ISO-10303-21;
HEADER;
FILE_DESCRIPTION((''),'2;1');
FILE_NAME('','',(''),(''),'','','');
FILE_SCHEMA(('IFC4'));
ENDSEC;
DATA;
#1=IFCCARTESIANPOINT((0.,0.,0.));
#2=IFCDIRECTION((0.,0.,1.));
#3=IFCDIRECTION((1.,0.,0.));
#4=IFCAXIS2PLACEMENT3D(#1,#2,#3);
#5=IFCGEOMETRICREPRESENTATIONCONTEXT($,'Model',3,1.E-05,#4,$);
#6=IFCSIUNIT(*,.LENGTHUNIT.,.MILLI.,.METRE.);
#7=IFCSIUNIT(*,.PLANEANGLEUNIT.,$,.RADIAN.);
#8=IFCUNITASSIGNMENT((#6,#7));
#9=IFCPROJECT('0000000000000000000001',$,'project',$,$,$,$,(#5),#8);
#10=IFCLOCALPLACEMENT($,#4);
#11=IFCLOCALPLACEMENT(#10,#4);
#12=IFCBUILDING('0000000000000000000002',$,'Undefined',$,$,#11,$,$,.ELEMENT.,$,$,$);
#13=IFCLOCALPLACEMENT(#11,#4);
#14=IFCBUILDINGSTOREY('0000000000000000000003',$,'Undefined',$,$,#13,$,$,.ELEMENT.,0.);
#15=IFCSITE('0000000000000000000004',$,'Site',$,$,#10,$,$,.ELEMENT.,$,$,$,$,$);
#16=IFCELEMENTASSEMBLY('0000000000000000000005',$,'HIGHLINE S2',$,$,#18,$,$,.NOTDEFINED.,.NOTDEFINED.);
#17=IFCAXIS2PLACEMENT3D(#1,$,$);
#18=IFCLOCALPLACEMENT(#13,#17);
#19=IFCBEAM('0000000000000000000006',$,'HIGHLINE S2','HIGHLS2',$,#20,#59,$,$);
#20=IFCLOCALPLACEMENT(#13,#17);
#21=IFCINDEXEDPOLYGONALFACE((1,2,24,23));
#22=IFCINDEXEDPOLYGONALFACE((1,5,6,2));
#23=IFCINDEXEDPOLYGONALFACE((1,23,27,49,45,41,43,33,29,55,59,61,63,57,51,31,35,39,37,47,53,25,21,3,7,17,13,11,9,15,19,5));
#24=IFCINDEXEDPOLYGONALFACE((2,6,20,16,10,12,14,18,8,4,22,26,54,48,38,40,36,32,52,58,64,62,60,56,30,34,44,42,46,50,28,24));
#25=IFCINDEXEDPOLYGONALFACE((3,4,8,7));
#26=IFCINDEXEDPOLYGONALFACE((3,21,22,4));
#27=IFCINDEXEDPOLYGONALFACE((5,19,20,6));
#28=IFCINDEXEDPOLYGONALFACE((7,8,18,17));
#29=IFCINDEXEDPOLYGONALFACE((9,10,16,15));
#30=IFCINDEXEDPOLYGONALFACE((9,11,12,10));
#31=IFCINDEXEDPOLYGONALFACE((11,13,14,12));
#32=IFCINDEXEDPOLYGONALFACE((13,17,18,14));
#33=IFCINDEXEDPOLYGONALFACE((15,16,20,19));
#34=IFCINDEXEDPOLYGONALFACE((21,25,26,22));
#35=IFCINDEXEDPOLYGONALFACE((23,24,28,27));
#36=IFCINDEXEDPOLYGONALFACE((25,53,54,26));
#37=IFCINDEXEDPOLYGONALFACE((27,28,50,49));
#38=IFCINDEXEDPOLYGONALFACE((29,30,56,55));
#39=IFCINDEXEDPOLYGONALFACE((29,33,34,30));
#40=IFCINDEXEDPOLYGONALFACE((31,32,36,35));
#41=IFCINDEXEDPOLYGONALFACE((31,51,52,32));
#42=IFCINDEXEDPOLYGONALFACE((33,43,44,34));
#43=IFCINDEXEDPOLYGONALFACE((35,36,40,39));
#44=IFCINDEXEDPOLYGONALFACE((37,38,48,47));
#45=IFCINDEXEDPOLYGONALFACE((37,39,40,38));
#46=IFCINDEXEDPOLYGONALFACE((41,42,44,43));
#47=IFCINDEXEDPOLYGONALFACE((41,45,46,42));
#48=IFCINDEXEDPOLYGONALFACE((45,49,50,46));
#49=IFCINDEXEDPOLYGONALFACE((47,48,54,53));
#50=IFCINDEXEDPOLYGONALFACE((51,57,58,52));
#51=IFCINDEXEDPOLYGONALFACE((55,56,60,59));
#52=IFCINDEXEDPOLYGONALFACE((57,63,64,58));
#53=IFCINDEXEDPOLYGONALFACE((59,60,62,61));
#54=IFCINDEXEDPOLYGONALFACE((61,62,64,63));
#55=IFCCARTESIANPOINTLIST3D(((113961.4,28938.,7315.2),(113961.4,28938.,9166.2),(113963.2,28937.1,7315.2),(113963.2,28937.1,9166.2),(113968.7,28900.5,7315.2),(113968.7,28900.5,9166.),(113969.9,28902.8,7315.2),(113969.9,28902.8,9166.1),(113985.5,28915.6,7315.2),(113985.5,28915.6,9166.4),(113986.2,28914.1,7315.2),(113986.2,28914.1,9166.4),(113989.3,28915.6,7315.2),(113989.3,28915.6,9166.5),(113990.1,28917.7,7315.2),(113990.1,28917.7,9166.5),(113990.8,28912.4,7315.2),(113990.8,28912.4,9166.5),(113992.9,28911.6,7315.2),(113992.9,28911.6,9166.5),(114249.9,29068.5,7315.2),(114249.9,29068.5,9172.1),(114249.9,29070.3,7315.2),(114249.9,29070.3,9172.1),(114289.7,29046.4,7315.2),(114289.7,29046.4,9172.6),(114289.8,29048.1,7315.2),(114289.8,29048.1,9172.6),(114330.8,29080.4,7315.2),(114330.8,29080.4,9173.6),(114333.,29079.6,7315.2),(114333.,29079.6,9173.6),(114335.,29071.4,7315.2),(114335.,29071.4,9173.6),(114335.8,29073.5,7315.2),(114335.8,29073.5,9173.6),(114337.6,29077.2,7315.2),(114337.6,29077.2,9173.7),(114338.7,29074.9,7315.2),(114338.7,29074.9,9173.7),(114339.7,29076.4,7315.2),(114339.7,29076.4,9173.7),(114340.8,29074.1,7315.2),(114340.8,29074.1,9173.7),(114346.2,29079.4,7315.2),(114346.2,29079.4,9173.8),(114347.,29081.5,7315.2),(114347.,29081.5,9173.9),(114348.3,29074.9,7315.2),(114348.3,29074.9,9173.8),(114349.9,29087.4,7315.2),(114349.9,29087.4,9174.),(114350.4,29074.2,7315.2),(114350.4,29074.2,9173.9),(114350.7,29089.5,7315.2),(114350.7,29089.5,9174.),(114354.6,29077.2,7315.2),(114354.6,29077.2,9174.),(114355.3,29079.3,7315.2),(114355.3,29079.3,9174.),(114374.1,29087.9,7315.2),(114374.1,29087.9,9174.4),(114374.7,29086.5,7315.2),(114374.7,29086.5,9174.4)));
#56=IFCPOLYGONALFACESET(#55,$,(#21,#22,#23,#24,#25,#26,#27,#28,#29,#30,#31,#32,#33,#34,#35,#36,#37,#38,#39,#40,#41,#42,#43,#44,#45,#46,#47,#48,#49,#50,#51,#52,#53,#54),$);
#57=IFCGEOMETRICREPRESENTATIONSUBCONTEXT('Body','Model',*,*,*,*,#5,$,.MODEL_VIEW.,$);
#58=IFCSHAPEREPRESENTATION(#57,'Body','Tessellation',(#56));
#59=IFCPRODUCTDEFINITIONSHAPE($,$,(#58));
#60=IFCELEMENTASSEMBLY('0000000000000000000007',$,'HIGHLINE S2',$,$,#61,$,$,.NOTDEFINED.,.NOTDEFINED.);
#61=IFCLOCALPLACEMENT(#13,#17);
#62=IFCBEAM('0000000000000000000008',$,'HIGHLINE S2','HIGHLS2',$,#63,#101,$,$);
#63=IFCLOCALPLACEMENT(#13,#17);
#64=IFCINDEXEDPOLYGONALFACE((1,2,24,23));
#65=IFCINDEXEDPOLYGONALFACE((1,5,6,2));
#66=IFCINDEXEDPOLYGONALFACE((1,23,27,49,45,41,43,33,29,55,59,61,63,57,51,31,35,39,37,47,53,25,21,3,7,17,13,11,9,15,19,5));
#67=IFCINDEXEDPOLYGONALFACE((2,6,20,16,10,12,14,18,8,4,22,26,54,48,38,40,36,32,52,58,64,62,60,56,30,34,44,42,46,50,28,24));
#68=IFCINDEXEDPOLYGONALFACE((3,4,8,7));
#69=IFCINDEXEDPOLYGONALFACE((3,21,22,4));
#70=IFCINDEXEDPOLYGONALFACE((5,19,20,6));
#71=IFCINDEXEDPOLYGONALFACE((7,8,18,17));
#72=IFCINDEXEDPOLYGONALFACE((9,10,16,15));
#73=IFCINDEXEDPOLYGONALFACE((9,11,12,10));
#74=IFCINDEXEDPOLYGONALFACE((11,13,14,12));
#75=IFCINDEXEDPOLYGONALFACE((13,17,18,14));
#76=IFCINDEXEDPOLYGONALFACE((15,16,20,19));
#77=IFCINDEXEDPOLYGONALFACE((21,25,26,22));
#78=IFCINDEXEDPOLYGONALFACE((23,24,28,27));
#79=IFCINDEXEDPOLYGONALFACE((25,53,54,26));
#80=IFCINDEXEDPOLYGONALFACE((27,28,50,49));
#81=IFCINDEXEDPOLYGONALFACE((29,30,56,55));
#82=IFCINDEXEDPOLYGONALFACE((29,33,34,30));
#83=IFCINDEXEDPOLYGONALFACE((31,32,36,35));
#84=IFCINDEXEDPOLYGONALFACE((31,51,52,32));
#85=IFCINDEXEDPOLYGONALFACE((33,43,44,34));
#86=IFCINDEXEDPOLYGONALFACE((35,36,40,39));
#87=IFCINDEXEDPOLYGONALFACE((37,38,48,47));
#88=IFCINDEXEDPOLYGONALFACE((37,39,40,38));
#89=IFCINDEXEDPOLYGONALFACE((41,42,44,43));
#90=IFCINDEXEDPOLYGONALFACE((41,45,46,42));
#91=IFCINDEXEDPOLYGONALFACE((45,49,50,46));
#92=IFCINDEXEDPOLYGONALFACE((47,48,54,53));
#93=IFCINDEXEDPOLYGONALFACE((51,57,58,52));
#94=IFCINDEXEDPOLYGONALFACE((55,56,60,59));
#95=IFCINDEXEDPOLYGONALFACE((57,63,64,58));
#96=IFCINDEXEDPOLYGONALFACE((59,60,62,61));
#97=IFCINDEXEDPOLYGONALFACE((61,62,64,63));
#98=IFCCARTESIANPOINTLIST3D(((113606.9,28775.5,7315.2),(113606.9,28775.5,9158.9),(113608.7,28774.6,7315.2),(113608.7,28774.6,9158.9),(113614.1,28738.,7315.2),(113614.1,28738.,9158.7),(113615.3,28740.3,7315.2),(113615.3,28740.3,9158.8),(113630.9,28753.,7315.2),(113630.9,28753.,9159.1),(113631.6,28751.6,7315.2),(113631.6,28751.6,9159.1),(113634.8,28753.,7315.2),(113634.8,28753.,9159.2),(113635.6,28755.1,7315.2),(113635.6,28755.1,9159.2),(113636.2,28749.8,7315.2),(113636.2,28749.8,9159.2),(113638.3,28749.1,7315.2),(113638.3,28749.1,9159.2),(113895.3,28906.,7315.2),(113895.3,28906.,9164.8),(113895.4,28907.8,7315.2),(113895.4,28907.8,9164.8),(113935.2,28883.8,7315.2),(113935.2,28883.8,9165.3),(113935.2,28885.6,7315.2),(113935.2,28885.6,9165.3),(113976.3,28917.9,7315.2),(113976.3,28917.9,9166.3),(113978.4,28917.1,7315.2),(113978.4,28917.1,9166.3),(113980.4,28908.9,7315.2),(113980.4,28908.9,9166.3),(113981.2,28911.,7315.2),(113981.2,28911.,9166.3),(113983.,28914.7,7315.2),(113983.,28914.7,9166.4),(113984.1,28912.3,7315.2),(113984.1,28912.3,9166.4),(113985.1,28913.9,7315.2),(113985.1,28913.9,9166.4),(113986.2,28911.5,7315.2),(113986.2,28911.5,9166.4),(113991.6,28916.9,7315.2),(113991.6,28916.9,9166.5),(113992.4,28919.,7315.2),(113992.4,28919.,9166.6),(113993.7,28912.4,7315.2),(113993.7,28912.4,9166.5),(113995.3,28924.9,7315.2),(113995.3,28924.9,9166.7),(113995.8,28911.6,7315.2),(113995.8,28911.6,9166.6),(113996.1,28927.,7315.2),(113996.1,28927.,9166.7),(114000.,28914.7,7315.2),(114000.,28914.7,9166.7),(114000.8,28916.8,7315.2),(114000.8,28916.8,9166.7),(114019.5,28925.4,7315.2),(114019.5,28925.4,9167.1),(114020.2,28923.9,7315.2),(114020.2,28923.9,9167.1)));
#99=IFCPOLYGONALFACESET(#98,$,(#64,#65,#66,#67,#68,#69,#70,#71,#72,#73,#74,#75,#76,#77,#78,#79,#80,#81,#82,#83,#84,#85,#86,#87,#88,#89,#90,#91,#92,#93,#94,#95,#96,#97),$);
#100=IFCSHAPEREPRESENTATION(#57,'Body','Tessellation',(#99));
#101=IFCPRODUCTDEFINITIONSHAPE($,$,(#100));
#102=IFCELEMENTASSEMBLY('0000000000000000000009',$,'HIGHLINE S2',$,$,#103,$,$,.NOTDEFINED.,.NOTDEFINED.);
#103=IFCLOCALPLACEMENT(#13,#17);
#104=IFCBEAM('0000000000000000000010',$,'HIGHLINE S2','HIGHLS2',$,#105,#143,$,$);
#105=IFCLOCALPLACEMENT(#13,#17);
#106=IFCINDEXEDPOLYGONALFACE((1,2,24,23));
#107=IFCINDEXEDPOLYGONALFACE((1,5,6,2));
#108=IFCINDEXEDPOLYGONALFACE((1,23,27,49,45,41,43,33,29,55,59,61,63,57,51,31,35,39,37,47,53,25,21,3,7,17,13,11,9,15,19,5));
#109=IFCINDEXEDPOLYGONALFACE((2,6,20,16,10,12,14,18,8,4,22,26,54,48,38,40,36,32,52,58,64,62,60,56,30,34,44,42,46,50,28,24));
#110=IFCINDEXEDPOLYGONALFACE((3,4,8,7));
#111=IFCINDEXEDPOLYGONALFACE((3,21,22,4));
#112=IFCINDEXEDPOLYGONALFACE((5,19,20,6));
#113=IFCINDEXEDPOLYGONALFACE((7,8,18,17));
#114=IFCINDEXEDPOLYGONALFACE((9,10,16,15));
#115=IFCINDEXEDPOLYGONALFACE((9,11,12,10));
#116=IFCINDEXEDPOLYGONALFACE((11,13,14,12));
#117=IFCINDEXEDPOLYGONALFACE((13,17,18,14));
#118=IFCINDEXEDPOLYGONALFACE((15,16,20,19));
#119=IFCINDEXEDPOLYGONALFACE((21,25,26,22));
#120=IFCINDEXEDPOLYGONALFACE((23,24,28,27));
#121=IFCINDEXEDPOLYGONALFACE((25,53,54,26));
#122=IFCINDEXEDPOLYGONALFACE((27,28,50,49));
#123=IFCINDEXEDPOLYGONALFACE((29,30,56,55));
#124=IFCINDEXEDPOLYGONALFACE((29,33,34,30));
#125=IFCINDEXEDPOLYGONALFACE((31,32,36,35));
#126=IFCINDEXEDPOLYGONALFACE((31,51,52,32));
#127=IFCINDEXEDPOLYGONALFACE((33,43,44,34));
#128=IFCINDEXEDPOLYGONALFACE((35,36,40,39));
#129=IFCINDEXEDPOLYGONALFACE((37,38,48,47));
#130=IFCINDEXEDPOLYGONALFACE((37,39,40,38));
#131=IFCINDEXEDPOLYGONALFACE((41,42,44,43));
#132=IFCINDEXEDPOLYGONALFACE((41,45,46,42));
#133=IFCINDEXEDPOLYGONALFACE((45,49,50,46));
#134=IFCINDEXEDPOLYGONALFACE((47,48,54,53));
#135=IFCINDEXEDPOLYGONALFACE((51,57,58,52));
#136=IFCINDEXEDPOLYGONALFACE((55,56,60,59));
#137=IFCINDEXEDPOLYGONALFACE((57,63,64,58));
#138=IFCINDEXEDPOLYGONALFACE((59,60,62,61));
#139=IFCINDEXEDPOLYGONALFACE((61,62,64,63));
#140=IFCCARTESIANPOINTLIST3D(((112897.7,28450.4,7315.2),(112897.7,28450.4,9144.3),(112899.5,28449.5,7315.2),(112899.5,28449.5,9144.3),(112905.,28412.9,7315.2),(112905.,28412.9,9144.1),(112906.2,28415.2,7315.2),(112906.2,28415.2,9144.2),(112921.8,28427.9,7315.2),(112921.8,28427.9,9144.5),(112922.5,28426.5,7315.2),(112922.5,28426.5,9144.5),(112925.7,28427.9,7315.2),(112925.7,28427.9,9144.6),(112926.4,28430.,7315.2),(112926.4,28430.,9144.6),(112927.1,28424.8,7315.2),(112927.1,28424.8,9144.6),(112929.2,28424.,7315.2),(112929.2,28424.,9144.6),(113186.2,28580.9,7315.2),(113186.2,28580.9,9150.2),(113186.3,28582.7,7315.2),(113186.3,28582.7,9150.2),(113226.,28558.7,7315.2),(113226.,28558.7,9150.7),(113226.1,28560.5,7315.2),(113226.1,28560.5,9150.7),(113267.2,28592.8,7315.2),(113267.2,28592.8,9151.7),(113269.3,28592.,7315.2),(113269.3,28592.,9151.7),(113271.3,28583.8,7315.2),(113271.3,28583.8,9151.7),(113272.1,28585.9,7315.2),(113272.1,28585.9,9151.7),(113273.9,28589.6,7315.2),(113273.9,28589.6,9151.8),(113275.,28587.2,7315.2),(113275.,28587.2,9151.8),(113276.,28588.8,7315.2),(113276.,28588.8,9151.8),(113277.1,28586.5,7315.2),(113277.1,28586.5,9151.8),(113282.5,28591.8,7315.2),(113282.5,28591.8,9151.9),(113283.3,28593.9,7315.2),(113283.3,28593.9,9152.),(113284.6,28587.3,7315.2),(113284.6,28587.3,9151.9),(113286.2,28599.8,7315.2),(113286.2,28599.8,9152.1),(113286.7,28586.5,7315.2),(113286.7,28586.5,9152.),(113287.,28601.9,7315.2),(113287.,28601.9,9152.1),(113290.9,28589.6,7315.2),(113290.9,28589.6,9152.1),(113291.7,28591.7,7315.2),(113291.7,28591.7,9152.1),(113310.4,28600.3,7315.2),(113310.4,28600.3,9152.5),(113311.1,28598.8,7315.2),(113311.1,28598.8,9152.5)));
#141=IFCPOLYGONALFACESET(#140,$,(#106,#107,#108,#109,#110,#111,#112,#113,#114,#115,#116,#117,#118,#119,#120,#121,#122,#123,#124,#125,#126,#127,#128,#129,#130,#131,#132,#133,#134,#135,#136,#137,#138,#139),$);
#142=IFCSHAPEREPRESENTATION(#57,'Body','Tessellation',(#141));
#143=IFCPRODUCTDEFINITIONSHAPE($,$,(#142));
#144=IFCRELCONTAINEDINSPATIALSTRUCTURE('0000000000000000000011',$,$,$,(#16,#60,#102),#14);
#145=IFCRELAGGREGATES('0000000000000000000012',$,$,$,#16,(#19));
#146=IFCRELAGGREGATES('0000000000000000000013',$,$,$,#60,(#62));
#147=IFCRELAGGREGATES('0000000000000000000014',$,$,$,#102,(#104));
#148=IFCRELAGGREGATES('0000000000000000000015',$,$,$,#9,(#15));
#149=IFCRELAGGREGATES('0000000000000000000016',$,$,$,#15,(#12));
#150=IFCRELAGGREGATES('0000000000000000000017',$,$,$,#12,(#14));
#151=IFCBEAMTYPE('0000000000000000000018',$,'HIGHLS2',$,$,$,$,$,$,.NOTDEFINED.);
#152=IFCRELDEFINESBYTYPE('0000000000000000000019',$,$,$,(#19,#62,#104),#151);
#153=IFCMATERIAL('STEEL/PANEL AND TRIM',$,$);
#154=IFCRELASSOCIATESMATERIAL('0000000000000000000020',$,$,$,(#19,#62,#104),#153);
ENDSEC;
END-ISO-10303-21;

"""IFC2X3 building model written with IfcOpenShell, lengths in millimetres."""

from ifc_helpers import new_model, si_unit, frame, origin_with_axes, place, context, subcontext, project, spatial, polyline, outline, extrude, boolean, halfspace, material, type_object, element, aggregate, save


model = new_model("IFC2X3")

# Units and contexts
model_context = context("Model", 3, precision=1e-05, world=origin_with_axes())
body_context = subcontext(model_context, "Body", "Model", "MODEL_VIEW")
ifc_project = project(units=[si_unit("LENGTHUNIT", "METRE", prefix="MILLI"), si_unit("PLANEANGLEUNIT", "RADIAN")], contexts=[model_context])

# Site, building, storey
site_placement = place(None, origin_with_axes())
site = spatial("IfcSite", under=ifc_project, at=site_placement, Name="Site", CompositionType="ELEMENT")
building_placement = place(site_placement, origin_with_axes())
building = spatial("IfcBuilding", under=site, at=building_placement, Name="Undefined", CompositionType="ELEMENT")
storey_placement = place(building_placement, origin_with_axes())
storey = spatial("IfcBuildingStorey", under=building, at=storey_placement, Name="Undefined", CompositionType="ELEMENT", Elevation=0.0)

# Element assemblies, beams
assembly_1_placement = place(storey_placement, origin_with_axes())
assembly_1 = element("IfcElementAssembly", 1, at=assembly_1_placement, inside=storey, Name="HIGHLINE S2", AssemblyPlace="NOTDEFINED", PredefinedType="NOTDEFINED")
ifc_material_1 = material(Name="STEEL/PANEL AND TRIM")
beam_type_1 = type_object("IfcBeamType", Name="HIGHLS2", PredefinedType="NOTDEFINED")
beam_1_placement = place(assembly_1_placement, frame((113961.4, 28938.0, 4267.2), z_axis=(0.41674, -0.909026, 0.0), x_axis=(0.0, 0.0, 1.0)))
beam_1 = element("IfcBeam", 2, at=beam_1_placement, type_object=beam_type_1, material=ifc_material_1, Name="HIGHLINE S2", Description="HIGHLS2", context=body_context, shape_type="CSG", body=[
    boolean("DIFFERENCE", boolean("DIFFERENCE", extrude(outline(polyline([(415.4, 26.1), (415.4, 37.3), (437.6, 37.3), (437.6, 35.7), (417.0, 35.7), (417.0, 24.5), (395.1, 24.5), (395.1, 34.4), (401.5, 34.4), (401.5, 31.9), (408.7, 31.9), (408.7, 36.8), (344.4, 36.8), (317.4, 0.0), (0.0, 0.0), (-9.0, 37.1), (17.6, 37.1), (17.6, 30.5), (12.5, 30.5), (12.5, 32.1), (16.0, 32.1), (16.0, 35.5), (-7.0, 35.5), (1.2, 1.6), (316.6, 1.6), (343.6, 38.4), (410.3, 38.4), (410.3, 30.3), (400.0, 30.3), (400.0, 32.8), (396.7, 32.8), (396.7, 26.1), (415.4, 26.1)])), frame((10000.0, 0.0, 0.0), z_axis=(-1.0, 0.0, 0.0), x_axis=(0.0, -1.0, 0.0)), (0.0, 0.0, 1.0), 10000.0), extrude(outline(polyline([(0.0, 0.0), (6400.8, 0.0), (6400.8, 3048.0), (0.0, 3048.0), (0.0, 0.0)])), frame((0.0, 3046.3, -9.8), z_axis=(0.0, 0.0, 1.0), x_axis=(0.0, -1.0, 0.0)), (0.0, 0.0, 1.0), 58.0)), halfspace(frame((4889.6, 500.0, 500.0), z_axis=(0.999825, 0.018709, 0.0), x_axis=(0.0, 0.0, -1.0)), False)),
])
aggregate(assembly_1, [beam_1])
assembly_2_placement = place(storey_placement, origin_with_axes())
assembly_2 = element("IfcElementAssembly", 3, at=assembly_2_placement, inside=storey, Name="HIGHLINE S2", AssemblyPlace="NOTDEFINED", PredefinedType="NOTDEFINED")
beam_2_placement = place(assembly_2_placement, frame((113606.9, 28775.5, 4267.2), z_axis=(0.41674, -0.909026, 0.0), x_axis=(0.0, 0.0, 1.0)))
beam_2 = element("IfcBeam", 4, at=beam_2_placement, type_object=beam_type_1, material=ifc_material_1, Name="HIGHLINE S2", Description="HIGHLS2", context=body_context, shape_type="CSG", body=[
    boolean("DIFFERENCE", boolean("DIFFERENCE", extrude(outline(polyline([(415.4, 26.1), (415.4, 37.3), (437.6, 37.3), (437.6, 35.7), (417.0, 35.7), (417.0, 24.5), (395.1, 24.5), (395.1, 34.4), (401.5, 34.4), (401.5, 31.9), (408.7, 31.9), (408.7, 36.8), (344.4, 36.8), (317.4, 0.0), (0.0, 0.0), (-9.0, 37.1), (17.6, 37.1), (17.6, 30.5), (12.5, 30.5), (12.5, 32.1), (16.0, 32.1), (16.0, 35.5), (-7.0, 35.5), (1.2, 1.6), (316.6, 1.6), (343.6, 38.4), (410.3, 38.4), (410.3, 30.3), (400.0, 30.3), (400.0, 32.8), (396.7, 32.8), (396.7, 26.1), (415.4, 26.1)])), frame((10000.0, 0.0, 0.0), z_axis=(-1.0, 0.0, 0.0), x_axis=(0.0, -1.0, 0.0)), (0.0, 0.0, 1.0), 10000.0), extrude(outline(polyline([(0.0, 0.0), (6400.8, 0.0), (6400.8, 3048.0), (0.0, 3048.0), (0.0, 0.0)])), frame((0.0, 2656.3, -9.8), z_axis=(0.0, 0.0, 1.0), x_axis=(0.0, -1.0, 0.0)), (0.0, 0.0, 1.0), 58.0)), halfspace(frame((4882.3, 500.0, 500.0), z_axis=(0.999825, 0.018709, 0.0), x_axis=(0.0, 0.0, -1.0)), False)),
])
aggregate(assembly_2, [beam_2])
assembly_3_placement = place(storey_placement, origin_with_axes())
assembly_3 = element("IfcElementAssembly", 5, at=assembly_3_placement, inside=storey, Name="HIGHLINE S2", AssemblyPlace="NOTDEFINED", PredefinedType="NOTDEFINED")
beam_3_placement = place(assembly_3_placement, frame((112897.7, 28450.4, 4267.2), z_axis=(0.41674, -0.909026, 0.0), x_axis=(0.0, 0.0, 1.0)))
beam_3 = element("IfcBeam", 6, at=beam_3_placement, type_object=beam_type_1, material=ifc_material_1, Name="HIGHLINE S2", Description="HIGHLS2", context=body_context, shape_type="CSG", body=[
    boolean("DIFFERENCE", boolean("DIFFERENCE", extrude(outline(polyline([(415.4, 26.1), (415.4, 37.3), (437.6, 37.3), (437.6, 35.7), (417.0, 35.7), (417.0, 24.5), (395.1, 24.5), (395.1, 34.4), (401.5, 34.4), (401.5, 31.9), (408.7, 31.9), (408.7, 36.8), (344.4, 36.8), (317.4, 0.0), (0.0, 0.0), (-9.0, 37.1), (17.6, 37.1), (17.6, 30.5), (12.5, 30.5), (12.5, 32.1), (16.0, 32.1), (16.0, 35.5), (-7.0, 35.5), (1.2, 1.6), (316.6, 1.6), (343.6, 38.4), (410.3, 38.4), (410.3, 30.3), (400.0, 30.3), (400.0, 32.8), (396.7, 32.8), (396.7, 26.1), (415.4, 26.1)])), frame((10000.0, 0.0, 0.0), z_axis=(-1.0, 0.0, 0.0), x_axis=(0.0, -1.0, 0.0)), (0.0, 0.0, 1.0), 10000.0), extrude(outline(polyline([(0.0, 0.0), (6400.8, 0.0), (6400.8, 3048.0), (0.0, 3048.0), (0.0, 0.0)])), frame((0.0, 1876.2, -9.8), z_axis=(0.0, 0.0, 1.0), x_axis=(0.0, -1.0, 0.0)), (0.0, 0.0, 1.0), 58.0)), halfspace(frame((4867.7, 500.0, 500.0), z_axis=(0.999825, 0.018709, 0.0), x_axis=(0.0, 0.0, -1.0)), False)),
])
aggregate(assembly_3, [beam_3])

save(model, "model.ifc")
